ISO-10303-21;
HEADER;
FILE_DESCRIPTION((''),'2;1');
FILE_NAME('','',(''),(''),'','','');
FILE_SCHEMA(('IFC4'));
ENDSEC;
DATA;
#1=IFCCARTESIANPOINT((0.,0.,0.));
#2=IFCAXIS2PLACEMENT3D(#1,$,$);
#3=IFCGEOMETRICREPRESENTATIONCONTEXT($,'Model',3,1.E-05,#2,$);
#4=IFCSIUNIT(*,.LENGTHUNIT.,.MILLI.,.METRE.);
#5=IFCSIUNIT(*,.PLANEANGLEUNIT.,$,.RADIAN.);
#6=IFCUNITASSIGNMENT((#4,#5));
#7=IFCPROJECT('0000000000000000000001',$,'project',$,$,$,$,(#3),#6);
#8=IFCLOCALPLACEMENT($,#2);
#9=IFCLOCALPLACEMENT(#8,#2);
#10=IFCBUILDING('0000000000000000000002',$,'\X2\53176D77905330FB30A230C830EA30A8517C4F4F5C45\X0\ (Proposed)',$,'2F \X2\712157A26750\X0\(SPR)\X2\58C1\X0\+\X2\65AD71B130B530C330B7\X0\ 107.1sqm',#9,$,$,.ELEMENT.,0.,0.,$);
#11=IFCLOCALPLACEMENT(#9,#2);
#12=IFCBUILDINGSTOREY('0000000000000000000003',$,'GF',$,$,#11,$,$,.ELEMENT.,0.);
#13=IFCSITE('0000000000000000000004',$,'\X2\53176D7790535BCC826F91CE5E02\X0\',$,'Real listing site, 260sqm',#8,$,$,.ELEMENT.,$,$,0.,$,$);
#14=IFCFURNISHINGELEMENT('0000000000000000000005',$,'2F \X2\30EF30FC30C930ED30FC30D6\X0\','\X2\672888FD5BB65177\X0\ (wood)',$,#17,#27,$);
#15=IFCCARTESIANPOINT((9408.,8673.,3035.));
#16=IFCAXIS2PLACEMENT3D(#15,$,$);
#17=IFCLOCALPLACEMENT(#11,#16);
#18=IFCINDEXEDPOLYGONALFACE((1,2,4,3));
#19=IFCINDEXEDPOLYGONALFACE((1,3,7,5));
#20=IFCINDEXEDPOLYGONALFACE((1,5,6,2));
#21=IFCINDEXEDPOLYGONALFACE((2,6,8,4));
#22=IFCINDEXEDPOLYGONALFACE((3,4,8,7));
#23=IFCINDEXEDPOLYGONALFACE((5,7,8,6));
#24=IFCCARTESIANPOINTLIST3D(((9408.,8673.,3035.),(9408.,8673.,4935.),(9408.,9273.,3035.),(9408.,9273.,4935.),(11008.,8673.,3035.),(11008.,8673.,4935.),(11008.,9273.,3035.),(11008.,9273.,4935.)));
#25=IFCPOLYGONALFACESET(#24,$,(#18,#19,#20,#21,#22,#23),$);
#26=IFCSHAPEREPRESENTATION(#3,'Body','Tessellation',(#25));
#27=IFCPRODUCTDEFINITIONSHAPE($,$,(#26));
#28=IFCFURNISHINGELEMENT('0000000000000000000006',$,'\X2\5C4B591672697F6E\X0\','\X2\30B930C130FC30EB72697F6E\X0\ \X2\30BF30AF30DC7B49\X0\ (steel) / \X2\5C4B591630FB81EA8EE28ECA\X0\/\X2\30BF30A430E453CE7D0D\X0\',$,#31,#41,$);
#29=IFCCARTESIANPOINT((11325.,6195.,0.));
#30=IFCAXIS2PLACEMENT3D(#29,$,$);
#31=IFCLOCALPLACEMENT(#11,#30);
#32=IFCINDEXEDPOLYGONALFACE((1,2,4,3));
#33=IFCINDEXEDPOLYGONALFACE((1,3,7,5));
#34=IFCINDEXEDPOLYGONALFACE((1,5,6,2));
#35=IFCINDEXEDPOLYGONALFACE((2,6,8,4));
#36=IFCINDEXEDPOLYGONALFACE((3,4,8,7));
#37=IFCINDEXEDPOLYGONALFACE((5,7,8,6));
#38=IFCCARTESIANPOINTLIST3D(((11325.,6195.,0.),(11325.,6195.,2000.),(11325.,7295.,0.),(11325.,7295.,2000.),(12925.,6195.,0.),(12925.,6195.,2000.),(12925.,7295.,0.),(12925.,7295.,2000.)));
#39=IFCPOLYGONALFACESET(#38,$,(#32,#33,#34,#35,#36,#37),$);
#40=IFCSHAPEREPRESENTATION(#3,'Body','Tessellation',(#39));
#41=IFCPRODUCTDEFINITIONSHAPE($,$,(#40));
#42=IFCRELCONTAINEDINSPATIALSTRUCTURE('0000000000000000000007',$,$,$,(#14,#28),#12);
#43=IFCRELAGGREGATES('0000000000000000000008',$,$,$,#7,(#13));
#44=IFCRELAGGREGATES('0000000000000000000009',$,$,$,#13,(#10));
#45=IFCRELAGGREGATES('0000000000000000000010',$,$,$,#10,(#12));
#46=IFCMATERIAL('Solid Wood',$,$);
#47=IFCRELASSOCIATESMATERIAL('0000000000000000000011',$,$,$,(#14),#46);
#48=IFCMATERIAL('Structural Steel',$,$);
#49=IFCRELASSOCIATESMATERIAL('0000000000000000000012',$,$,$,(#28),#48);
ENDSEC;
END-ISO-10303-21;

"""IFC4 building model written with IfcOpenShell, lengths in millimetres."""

from ifc_helpers import new_model, si_unit, frame, frame_2d, origin, place, context, project, spatial, rectangle, extrude, material, element, save


model = new_model("IFC4")

# Units and contexts
model_context = context("Model", 3, precision=1e-05, world=origin())
ifc_project = project(units=[si_unit("LENGTHUNIT", "METRE", prefix="MILLI"), si_unit("PLANEANGLEUNIT", "RADIAN")], contexts=[model_context])

# Site, building, storey
site_placement = place(None, origin())
site = spatial("IfcSite", under=ifc_project, at=site_placement, Name="北海道富良野市", ObjectType="Real listing site, 260sqm", CompositionType="ELEMENT", RefElevation=0.0)
building_placement = place(site_placement, origin())
building = spatial("IfcBuilding", under=site, at=building_placement, Name="北海道・アトリエ兼住居 (Proposed)", ObjectType="2F 無垢材(SPR)壁+断熱サッシ 107.1sqm", CompositionType="ELEMENT", ElevationOfRefHeight=0.0, ElevationOfTerrain=0.0)
storey_placement = place(building_placement, origin())
storey = spatial("IfcBuildingStorey", under=building, at=storey_placement, Name="GF", CompositionType="ELEMENT", Elevation=0.0)

# Shared definitions
ifc_material_1 = material(Name="Solid Wood")

# Shared definitions
ifc_material_2 = material(Name="Structural Steel")

# Furnishing elements
furnishing_1_placement = place(storey_placement, frame((9408.0, 8673.0, 3035.0)))
element("IfcFurnishingElement", 1, at=furnishing_1_placement, inside=storey, material=ifc_material_1, Name="2F ワードローブ", Description="木製家具 (wood)", context=model_context, shape_type="SweptSolid", body=[
    extrude(rectangle(XDim=1600.0, YDim=600.0, at=frame_2d((800.0, 300.0))), frame((9408.0, 8673.0, 3035.0)), (0.0, 0.0, 1.0), 1900.0),
])
furnishing_2_placement = place(storey_placement, frame((11325.0, 6195.0, 0.0)))
element("IfcFurnishingElement", 2, at=furnishing_2_placement, inside=storey, material=ifc_material_2, Name="屋外物置", Description="スチール物置 タクボ等 (steel) / 屋外・自転車/タイヤ収納", context=model_context, shape_type="SweptSolid", body=[
    extrude(rectangle(XDim=1600.0, YDim=1100.0, at=frame_2d((800.0, 550.0))), frame((11325.0, 6195.0, 0.0)), (0.0, 0.0, 1.0), 2000.0),
])

save(model, "model.ifc")
